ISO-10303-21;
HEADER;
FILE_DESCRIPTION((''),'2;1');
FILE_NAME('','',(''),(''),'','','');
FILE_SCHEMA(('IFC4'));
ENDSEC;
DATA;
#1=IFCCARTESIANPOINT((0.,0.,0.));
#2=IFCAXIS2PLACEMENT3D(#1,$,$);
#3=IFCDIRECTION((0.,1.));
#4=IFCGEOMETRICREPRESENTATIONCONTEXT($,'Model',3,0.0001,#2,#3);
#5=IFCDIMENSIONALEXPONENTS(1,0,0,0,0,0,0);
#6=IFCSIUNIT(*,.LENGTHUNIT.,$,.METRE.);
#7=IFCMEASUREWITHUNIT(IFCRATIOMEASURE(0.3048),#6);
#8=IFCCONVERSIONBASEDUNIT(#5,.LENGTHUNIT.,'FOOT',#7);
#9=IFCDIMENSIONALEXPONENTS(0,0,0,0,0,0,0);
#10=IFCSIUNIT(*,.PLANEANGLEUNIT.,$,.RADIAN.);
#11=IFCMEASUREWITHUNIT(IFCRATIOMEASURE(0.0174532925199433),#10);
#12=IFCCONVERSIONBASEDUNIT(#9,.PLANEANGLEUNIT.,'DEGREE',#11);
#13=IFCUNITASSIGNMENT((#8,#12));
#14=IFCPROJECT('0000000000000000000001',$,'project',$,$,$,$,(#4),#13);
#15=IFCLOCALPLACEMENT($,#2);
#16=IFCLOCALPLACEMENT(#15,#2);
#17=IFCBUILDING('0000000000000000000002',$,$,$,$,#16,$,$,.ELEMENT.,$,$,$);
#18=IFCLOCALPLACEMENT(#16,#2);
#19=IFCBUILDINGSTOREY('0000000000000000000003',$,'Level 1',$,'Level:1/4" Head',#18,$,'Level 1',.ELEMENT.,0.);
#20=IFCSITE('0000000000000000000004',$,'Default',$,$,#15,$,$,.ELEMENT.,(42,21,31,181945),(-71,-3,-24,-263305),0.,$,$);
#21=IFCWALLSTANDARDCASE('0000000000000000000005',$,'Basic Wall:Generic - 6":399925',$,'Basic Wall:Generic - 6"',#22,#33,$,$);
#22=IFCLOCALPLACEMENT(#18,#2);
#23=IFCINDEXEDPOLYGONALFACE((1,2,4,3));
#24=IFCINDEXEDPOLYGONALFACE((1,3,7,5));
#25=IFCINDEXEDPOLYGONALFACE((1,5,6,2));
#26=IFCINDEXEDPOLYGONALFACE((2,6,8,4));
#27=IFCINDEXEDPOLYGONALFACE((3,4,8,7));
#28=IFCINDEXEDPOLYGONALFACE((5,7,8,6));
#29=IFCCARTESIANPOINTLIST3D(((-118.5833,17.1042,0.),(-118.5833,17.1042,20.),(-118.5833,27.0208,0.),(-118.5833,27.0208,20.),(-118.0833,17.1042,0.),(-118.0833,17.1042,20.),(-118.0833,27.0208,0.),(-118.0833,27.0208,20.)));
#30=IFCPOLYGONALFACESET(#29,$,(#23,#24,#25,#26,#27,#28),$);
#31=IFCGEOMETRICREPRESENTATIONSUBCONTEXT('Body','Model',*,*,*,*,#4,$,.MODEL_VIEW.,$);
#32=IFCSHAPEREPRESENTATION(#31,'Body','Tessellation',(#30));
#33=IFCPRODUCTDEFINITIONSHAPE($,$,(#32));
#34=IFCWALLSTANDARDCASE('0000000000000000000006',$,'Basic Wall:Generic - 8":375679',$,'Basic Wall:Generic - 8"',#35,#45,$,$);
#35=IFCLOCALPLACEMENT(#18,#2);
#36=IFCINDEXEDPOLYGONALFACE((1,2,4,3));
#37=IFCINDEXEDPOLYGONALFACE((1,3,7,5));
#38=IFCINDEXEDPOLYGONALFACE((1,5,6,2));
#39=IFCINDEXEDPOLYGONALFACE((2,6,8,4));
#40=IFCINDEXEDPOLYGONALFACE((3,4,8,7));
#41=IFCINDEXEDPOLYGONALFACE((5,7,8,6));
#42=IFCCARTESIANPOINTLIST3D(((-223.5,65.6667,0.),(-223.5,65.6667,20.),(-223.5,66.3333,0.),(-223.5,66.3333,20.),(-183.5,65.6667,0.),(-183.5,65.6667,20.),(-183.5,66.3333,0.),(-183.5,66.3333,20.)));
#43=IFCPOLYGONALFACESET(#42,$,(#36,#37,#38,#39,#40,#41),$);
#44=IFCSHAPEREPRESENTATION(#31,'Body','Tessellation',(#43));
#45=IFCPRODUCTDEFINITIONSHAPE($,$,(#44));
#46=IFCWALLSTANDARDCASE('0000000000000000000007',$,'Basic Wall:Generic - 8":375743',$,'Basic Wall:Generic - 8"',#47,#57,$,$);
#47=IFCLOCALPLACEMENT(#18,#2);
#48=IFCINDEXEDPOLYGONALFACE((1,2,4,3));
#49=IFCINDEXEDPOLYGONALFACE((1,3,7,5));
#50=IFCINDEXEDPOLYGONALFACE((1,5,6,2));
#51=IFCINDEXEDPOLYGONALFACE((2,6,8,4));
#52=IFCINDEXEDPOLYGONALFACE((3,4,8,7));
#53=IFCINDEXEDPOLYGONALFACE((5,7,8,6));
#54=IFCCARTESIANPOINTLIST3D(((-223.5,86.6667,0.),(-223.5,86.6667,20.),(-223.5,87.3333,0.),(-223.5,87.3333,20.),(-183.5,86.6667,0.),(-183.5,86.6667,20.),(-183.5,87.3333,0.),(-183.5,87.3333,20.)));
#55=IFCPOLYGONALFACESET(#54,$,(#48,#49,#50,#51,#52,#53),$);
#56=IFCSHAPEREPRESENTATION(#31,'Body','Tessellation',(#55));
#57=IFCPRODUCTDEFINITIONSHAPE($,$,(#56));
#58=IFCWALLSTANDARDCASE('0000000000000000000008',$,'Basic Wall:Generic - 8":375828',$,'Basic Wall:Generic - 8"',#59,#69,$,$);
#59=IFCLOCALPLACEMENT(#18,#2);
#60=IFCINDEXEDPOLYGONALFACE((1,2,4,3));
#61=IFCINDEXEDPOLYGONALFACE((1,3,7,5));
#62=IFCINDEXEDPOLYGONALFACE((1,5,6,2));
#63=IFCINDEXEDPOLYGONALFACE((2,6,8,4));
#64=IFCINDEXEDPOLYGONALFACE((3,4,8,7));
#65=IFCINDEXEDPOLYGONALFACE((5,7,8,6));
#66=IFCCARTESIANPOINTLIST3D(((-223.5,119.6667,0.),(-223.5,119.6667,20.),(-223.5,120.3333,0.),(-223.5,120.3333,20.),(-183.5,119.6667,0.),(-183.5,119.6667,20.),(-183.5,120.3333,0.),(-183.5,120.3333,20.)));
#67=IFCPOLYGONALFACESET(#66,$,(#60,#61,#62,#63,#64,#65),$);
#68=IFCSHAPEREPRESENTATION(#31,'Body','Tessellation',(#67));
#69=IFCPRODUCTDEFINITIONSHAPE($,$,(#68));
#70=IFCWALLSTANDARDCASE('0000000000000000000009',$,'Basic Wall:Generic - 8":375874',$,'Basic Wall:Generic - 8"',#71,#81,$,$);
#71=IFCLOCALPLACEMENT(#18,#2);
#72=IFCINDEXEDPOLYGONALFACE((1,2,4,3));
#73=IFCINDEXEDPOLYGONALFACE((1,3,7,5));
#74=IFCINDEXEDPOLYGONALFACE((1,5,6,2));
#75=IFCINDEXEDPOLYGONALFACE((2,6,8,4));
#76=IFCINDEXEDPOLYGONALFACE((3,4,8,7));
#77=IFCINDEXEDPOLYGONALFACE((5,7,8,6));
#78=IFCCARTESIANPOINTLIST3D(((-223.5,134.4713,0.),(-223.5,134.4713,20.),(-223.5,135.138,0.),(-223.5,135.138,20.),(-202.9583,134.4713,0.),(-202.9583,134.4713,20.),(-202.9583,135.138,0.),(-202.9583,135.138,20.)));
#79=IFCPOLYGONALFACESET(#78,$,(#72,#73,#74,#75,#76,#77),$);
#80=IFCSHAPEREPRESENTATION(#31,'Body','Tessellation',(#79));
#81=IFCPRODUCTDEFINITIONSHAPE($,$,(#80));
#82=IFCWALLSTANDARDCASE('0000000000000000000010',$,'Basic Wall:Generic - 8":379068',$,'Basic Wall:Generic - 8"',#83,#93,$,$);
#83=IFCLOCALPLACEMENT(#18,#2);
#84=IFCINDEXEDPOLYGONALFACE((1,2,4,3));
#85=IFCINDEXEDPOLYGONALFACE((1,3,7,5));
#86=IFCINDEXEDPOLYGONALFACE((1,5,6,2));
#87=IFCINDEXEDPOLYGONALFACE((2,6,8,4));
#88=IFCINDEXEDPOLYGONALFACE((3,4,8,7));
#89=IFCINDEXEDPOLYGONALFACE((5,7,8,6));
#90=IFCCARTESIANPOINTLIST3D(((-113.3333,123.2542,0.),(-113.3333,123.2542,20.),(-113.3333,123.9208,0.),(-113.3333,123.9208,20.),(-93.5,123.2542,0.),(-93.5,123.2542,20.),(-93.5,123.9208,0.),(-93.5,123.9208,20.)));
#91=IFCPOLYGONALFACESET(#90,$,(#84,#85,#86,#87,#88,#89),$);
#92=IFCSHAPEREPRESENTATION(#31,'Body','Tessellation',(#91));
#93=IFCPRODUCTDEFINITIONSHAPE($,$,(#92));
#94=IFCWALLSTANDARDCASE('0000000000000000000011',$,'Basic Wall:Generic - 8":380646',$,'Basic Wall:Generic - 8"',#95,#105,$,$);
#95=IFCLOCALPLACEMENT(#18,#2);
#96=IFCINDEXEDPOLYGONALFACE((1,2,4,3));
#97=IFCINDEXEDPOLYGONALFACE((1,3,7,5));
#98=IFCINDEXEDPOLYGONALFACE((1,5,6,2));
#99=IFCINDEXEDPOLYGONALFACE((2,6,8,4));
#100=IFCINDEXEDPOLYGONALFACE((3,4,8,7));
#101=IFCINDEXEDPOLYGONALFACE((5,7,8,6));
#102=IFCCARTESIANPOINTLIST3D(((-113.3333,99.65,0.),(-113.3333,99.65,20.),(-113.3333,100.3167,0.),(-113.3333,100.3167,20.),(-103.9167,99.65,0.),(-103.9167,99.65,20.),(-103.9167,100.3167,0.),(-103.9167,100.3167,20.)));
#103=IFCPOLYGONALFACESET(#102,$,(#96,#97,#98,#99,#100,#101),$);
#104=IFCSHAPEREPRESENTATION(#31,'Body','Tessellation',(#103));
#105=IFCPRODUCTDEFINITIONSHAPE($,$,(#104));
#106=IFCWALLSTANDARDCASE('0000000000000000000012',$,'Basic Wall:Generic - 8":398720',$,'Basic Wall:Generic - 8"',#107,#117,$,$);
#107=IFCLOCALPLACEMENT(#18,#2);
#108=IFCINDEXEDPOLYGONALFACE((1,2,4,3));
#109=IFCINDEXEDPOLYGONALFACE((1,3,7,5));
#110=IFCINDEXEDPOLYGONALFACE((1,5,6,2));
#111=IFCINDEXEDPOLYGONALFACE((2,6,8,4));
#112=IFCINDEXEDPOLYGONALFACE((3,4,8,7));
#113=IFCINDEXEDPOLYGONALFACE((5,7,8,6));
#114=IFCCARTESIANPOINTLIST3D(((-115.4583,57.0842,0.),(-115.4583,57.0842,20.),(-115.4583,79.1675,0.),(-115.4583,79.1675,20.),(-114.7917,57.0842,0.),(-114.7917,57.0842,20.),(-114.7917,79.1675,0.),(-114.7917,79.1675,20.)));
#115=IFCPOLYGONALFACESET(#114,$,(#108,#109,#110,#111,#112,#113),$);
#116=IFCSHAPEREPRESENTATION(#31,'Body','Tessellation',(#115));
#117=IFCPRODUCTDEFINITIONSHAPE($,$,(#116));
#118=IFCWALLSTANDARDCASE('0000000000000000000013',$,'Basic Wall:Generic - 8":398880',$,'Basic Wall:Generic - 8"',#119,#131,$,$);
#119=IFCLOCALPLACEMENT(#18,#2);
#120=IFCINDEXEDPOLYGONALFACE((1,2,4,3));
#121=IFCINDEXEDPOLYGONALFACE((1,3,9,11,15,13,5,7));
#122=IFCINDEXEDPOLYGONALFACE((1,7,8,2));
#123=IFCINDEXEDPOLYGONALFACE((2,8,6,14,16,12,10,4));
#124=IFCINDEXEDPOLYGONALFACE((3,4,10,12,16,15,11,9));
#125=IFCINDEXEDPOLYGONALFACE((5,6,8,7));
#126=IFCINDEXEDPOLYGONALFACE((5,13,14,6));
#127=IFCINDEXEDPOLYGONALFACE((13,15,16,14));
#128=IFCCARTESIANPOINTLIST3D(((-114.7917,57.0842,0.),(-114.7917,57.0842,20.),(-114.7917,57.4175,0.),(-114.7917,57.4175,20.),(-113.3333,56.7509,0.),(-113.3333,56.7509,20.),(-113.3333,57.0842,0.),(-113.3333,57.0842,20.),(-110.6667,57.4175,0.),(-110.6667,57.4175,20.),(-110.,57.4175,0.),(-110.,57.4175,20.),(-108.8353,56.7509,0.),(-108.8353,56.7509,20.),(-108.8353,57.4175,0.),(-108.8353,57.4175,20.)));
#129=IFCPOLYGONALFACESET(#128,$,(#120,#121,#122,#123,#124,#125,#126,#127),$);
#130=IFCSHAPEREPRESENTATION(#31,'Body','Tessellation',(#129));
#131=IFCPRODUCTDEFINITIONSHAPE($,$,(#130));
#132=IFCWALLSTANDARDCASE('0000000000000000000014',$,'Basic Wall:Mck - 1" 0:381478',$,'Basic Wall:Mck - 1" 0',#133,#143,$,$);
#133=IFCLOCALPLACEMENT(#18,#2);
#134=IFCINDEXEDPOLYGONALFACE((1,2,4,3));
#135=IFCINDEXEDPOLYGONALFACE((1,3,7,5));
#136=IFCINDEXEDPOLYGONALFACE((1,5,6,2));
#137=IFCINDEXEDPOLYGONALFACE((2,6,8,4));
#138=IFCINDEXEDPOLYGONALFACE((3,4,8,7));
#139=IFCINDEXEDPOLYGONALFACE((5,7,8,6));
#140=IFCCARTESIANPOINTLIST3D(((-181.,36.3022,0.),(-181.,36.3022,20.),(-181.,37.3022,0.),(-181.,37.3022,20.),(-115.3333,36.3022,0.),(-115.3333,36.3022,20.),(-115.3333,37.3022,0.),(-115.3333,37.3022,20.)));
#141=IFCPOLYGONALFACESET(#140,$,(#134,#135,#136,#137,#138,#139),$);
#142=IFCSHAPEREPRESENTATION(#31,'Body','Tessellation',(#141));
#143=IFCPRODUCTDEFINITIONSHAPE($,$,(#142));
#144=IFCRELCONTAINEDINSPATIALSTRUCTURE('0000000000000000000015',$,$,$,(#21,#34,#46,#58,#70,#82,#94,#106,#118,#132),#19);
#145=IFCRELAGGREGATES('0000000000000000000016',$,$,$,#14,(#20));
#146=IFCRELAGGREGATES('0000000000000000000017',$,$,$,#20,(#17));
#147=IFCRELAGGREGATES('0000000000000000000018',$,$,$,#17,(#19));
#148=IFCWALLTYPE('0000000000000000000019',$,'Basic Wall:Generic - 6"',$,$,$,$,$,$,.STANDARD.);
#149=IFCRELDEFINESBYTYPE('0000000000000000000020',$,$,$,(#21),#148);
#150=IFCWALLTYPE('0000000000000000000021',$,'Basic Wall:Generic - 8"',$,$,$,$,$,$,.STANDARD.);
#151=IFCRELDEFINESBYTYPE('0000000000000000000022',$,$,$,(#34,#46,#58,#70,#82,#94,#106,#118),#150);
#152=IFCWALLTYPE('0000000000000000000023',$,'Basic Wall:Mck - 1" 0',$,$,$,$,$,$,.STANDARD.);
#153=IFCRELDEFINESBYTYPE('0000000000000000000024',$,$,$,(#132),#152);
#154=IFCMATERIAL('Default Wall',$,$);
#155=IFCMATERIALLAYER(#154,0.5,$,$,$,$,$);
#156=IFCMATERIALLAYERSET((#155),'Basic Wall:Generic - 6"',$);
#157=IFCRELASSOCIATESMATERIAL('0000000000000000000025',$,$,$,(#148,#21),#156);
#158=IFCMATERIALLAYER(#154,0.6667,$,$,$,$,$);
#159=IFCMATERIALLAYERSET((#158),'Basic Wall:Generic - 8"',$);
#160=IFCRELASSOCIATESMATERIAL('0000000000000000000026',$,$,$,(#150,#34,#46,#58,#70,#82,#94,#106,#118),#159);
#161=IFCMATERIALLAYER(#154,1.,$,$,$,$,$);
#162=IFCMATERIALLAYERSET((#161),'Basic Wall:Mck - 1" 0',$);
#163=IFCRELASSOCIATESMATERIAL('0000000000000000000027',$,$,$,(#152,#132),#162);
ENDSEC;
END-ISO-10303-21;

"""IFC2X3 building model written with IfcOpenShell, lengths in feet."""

from ifc_helpers import new_model, entity, si_unit, converted_unit, direction, frame, frame_2d, origin, place, context, subcontext, project, spatial, polyline, rectangle, outline, extrude, material, layer, layer_set, layer_usage, type_object, element, save


model = new_model("IFC2X3")

# Units and contexts
model_context = context("Model", 3, precision=0.0001, world=origin(), true_north=direction((0.0, 1.0)))
body_context = subcontext(model_context, "Body", "Model", "MODEL_VIEW")
ifc_project = project(units=[converted_unit("LENGTHUNIT", "FOOT", entity("IfcRatioMeasure", 0.3048), si_unit("LENGTHUNIT", "METRE"), dimensions=[1, 0, 0, 0, 0, 0, 0]), converted_unit("PLANEANGLEUNIT", "DEGREE", entity("IfcRatioMeasure", 0.0174532925199433), si_unit("PLANEANGLEUNIT", "RADIAN"), dimensions=[0, 0, 0, 0, 0, 0, 0])], contexts=[model_context])

# Site, building, storey
site_placement = place(None, origin())
site = spatial("IfcSite", under=ifc_project, at=site_placement, Name="Default", CompositionType="ELEMENT", RefLatitude=(42, 21, 31, 181945), RefLongitude=(-71, -3, -24, -263305), RefElevation=0.0)
building_placement = place(site_placement, origin())
building = spatial("IfcBuilding", under=site, at=building_placement, CompositionType="ELEMENT")
storey_placement = place(building_placement, origin())
storey = spatial("IfcBuildingStorey", under=building, at=storey_placement, Name="Level 1", ObjectType="Level:1/4\" Head", LongName="Level 1", CompositionType="ELEMENT", Elevation=0.0)

# Walls
ifc_material = material(Name="Default Wall")
ifc_layer_1 = layer(ifc_material, 0.5)
ifc_layer_set_1 = layer_set([ifc_layer_1], Name="Basic Wall:Generic - 6\"")
wall_type_1 = type_object("IfcWallType", Name="Basic Wall:Generic - 6\"", PredefinedType="STANDARD", material=ifc_layer_set_1)
ifc_layer_usage_1 = layer_usage(ifc_layer_set_1, "AXIS2", "NEGATIVE", 0.25)
wall_1_placement = place(storey_placement, frame((-118.3333, 27.0208, 0.0), z_axis=(0.0, 0.0, 1.0), x_axis=(0.0, -1.0, 0.0)))
element("IfcWallStandardCase", 1, at=wall_1_placement, inside=storey, type_object=wall_type_1, material=ifc_layer_usage_1, Name="Basic Wall:Generic - 6\":399925", ObjectType="Basic Wall:Generic - 6\"", context=body_context, shape_type="SweptSolid", body=[
    extrude(rectangle(XDim=9.9167, YDim=0.5, at=frame_2d((4.9583, 0.0), x_axis=(-1.0, 0.0))), origin(), (0.0, 0.0, 1.0), 20.0),
])
ifc_layer_2 = layer(ifc_material, 0.6667)
ifc_layer_set_2 = layer_set([ifc_layer_2], Name="Basic Wall:Generic - 8\"")
ifc_layer_usage_2 = layer_usage(ifc_layer_set_2, "AXIS2", "NEGATIVE", 0.3333)
wall_type_2 = type_object("IfcWallType", Name="Basic Wall:Generic - 8\"", PredefinedType="STANDARD", material=ifc_layer_set_2)
wall_2_placement = place(storey_placement, frame((-223.5, 66.0, 0.0)))
element("IfcWallStandardCase", 2, at=wall_2_placement, inside=storey, type_object=wall_type_2, material=ifc_layer_usage_2, Name="Basic Wall:Generic - 8\":375679", ObjectType="Basic Wall:Generic - 8\"", context=body_context, shape_type="SweptSolid", body=[
    extrude(rectangle(XDim=40.0, YDim=0.6667, at=frame_2d((20.0, 0.0), x_axis=(-1.0, 0.0))), origin(), (0.0, 0.0, 1.0), 20.0),
])
ifc_layer_usage_3 = layer_usage(ifc_layer_set_2, "AXIS2", "NEGATIVE", 0.3333)
wall_3_placement = place(storey_placement, frame((-223.5, 87.0, 0.0)))
element("IfcWallStandardCase", 3, at=wall_3_placement, inside=storey, type_object=wall_type_2, material=ifc_layer_usage_3, Name="Basic Wall:Generic - 8\":375743", ObjectType="Basic Wall:Generic - 8\"", context=body_context, shape_type="SweptSolid", body=[
    extrude(rectangle(XDim=40.0, YDim=0.6667, at=frame_2d((20.0, 0.0), x_axis=(-1.0, 0.0))), origin(), (0.0, 0.0, 1.0), 20.0),
])
ifc_layer_usage_4 = layer_usage(ifc_layer_set_2, "AXIS2", "NEGATIVE", 0.3333)
wall_4_placement = place(storey_placement, frame((-223.5, 120.0, 0.0)))
element("IfcWallStandardCase", 4, at=wall_4_placement, inside=storey, type_object=wall_type_2, material=ifc_layer_usage_4, Name="Basic Wall:Generic - 8\":375828", ObjectType="Basic Wall:Generic - 8\"", context=body_context, shape_type="SweptSolid", body=[
    extrude(rectangle(XDim=40.0, YDim=0.6667, at=frame_2d((20.0, 0.0), x_axis=(-1.0, 0.0))), origin(), (0.0, 0.0, 1.0), 20.0),
])
ifc_layer_usage_5 = layer_usage(ifc_layer_set_2, "AXIS2", "NEGATIVE", 0.3333)
wall_5_placement = place(storey_placement, frame((-223.5, 134.8046, 0.0)))
element("IfcWallStandardCase", 5, at=wall_5_placement, inside=storey, type_object=wall_type_2, material=ifc_layer_usage_5, Name="Basic Wall:Generic - 8\":375874", ObjectType="Basic Wall:Generic - 8\"", context=body_context, shape_type="SweptSolid", body=[
    extrude(rectangle(XDim=20.5417, YDim=0.6667, at=frame_2d((10.2708, 0.0), x_axis=(-1.0, 0.0))), origin(), (0.0, 0.0, 1.0), 20.0),
])
ifc_layer_usage_6 = layer_usage(ifc_layer_set_2, "AXIS2", "NEGATIVE", 0.3333)
wall_6_placement = place(storey_placement, frame((-113.3333, 123.5875, 0.0)))
element("IfcWallStandardCase", 6, at=wall_6_placement, inside=storey, type_object=wall_type_2, material=ifc_layer_usage_6, Name="Basic Wall:Generic - 8\":379068", ObjectType="Basic Wall:Generic - 8\"", context=body_context, shape_type="SweptSolid", body=[
    extrude(rectangle(XDim=19.8333, YDim=0.6667, at=frame_2d((9.9167, 0.0), x_axis=(-1.0, 0.0))), origin(), (0.0, 0.0, 1.0), 20.0),
])
ifc_layer_usage_7 = layer_usage(ifc_layer_set_2, "AXIS2", "NEGATIVE", 0.3333)
wall_7_placement = place(storey_placement, frame((-113.3333, 99.9833, 0.0)))
element("IfcWallStandardCase", 7, at=wall_7_placement, inside=storey, type_object=wall_type_2, material=ifc_layer_usage_7, Name="Basic Wall:Generic - 8\":380646", ObjectType="Basic Wall:Generic - 8\"", context=body_context, shape_type="SweptSolid", body=[
    extrude(rectangle(XDim=9.4167, YDim=0.6667, at=frame_2d((4.7083, 0.0), x_axis=(-1.0, 0.0))), origin(), (0.0, 0.0, 1.0), 20.0),
])
ifc_layer_usage_8 = layer_usage(ifc_layer_set_2, "AXIS2", "NEGATIVE", 0.3333)
wall_8_placement = place(storey_placement, frame((-115.125, 79.1675, 0.0), z_axis=(0.0, 0.0, 1.0), x_axis=(0.0, -1.0, 0.0)))
element("IfcWallStandardCase", 8, at=wall_8_placement, inside=storey, type_object=wall_type_2, material=ifc_layer_usage_8, Name="Basic Wall:Generic - 8\":398720", ObjectType="Basic Wall:Generic - 8\"", context=body_context, shape_type="SweptSolid", body=[
    extrude(rectangle(XDim=22.0833, YDim=0.6667, at=frame_2d((11.0417, 0.0), x_axis=(-1.0, 0.0))), origin(), (0.0, 0.0, 1.0), 20.0),
])
ifc_layer_usage_9 = layer_usage(ifc_layer_set_2, "AXIS2", "NEGATIVE", 0.3333)
wall_9_placement = place(storey_placement, frame((-114.7917, 57.0842, 0.0)))
element("IfcWallStandardCase", 9, at=wall_9_placement, inside=storey, type_object=wall_type_2, material=ifc_layer_usage_9, Name="Basic Wall:Generic - 8\":398880", ObjectType="Basic Wall:Generic - 8\"", context=body_context, shape_type="SweptSolid", body=[
    extrude(outline(polyline([(5.9564, -0.3333), (5.9564, 0.3333), (4.7917, 0.3333), (4.125, 0.3333), (0.0, 0.3333), (0.0, 0.0), (1.4583, 0.0), (1.4583, -0.3333), (5.9564, -0.3333)])), origin(), (0.0, 0.0, 1.0), 20.0),
])
ifc_layer_3 = layer(ifc_material, 1.0)
ifc_layer_set_3 = layer_set([ifc_layer_3], Name="Basic Wall:Mck - 1\" 0")
ifc_layer_usage_10 = layer_usage(ifc_layer_set_3, "AXIS2", "NEGATIVE", 0.5)
wall_type_3 = type_object("IfcWallType", Name="Basic Wall:Mck - 1\" 0", PredefinedType="STANDARD", material=ifc_layer_set_3)
wall_10_placement = place(storey_placement, frame((-181.0, 36.8022, 0.0)))
element("IfcWallStandardCase", 10, at=wall_10_placement, inside=storey, type_object=wall_type_3, material=ifc_layer_usage_10, Name="Basic Wall:Mck - 1\" 0:381478", ObjectType="Basic Wall:Mck - 1\" 0", context=body_context, shape_type="SweptSolid", body=[
    extrude(rectangle(XDim=65.6667, YDim=1.0, at=frame_2d((32.8333, 0.0), x_axis=(-1.0, 0.0))), origin(), (0.0, 0.0, 1.0), 20.0),
])

save(model, "model.ifc")
